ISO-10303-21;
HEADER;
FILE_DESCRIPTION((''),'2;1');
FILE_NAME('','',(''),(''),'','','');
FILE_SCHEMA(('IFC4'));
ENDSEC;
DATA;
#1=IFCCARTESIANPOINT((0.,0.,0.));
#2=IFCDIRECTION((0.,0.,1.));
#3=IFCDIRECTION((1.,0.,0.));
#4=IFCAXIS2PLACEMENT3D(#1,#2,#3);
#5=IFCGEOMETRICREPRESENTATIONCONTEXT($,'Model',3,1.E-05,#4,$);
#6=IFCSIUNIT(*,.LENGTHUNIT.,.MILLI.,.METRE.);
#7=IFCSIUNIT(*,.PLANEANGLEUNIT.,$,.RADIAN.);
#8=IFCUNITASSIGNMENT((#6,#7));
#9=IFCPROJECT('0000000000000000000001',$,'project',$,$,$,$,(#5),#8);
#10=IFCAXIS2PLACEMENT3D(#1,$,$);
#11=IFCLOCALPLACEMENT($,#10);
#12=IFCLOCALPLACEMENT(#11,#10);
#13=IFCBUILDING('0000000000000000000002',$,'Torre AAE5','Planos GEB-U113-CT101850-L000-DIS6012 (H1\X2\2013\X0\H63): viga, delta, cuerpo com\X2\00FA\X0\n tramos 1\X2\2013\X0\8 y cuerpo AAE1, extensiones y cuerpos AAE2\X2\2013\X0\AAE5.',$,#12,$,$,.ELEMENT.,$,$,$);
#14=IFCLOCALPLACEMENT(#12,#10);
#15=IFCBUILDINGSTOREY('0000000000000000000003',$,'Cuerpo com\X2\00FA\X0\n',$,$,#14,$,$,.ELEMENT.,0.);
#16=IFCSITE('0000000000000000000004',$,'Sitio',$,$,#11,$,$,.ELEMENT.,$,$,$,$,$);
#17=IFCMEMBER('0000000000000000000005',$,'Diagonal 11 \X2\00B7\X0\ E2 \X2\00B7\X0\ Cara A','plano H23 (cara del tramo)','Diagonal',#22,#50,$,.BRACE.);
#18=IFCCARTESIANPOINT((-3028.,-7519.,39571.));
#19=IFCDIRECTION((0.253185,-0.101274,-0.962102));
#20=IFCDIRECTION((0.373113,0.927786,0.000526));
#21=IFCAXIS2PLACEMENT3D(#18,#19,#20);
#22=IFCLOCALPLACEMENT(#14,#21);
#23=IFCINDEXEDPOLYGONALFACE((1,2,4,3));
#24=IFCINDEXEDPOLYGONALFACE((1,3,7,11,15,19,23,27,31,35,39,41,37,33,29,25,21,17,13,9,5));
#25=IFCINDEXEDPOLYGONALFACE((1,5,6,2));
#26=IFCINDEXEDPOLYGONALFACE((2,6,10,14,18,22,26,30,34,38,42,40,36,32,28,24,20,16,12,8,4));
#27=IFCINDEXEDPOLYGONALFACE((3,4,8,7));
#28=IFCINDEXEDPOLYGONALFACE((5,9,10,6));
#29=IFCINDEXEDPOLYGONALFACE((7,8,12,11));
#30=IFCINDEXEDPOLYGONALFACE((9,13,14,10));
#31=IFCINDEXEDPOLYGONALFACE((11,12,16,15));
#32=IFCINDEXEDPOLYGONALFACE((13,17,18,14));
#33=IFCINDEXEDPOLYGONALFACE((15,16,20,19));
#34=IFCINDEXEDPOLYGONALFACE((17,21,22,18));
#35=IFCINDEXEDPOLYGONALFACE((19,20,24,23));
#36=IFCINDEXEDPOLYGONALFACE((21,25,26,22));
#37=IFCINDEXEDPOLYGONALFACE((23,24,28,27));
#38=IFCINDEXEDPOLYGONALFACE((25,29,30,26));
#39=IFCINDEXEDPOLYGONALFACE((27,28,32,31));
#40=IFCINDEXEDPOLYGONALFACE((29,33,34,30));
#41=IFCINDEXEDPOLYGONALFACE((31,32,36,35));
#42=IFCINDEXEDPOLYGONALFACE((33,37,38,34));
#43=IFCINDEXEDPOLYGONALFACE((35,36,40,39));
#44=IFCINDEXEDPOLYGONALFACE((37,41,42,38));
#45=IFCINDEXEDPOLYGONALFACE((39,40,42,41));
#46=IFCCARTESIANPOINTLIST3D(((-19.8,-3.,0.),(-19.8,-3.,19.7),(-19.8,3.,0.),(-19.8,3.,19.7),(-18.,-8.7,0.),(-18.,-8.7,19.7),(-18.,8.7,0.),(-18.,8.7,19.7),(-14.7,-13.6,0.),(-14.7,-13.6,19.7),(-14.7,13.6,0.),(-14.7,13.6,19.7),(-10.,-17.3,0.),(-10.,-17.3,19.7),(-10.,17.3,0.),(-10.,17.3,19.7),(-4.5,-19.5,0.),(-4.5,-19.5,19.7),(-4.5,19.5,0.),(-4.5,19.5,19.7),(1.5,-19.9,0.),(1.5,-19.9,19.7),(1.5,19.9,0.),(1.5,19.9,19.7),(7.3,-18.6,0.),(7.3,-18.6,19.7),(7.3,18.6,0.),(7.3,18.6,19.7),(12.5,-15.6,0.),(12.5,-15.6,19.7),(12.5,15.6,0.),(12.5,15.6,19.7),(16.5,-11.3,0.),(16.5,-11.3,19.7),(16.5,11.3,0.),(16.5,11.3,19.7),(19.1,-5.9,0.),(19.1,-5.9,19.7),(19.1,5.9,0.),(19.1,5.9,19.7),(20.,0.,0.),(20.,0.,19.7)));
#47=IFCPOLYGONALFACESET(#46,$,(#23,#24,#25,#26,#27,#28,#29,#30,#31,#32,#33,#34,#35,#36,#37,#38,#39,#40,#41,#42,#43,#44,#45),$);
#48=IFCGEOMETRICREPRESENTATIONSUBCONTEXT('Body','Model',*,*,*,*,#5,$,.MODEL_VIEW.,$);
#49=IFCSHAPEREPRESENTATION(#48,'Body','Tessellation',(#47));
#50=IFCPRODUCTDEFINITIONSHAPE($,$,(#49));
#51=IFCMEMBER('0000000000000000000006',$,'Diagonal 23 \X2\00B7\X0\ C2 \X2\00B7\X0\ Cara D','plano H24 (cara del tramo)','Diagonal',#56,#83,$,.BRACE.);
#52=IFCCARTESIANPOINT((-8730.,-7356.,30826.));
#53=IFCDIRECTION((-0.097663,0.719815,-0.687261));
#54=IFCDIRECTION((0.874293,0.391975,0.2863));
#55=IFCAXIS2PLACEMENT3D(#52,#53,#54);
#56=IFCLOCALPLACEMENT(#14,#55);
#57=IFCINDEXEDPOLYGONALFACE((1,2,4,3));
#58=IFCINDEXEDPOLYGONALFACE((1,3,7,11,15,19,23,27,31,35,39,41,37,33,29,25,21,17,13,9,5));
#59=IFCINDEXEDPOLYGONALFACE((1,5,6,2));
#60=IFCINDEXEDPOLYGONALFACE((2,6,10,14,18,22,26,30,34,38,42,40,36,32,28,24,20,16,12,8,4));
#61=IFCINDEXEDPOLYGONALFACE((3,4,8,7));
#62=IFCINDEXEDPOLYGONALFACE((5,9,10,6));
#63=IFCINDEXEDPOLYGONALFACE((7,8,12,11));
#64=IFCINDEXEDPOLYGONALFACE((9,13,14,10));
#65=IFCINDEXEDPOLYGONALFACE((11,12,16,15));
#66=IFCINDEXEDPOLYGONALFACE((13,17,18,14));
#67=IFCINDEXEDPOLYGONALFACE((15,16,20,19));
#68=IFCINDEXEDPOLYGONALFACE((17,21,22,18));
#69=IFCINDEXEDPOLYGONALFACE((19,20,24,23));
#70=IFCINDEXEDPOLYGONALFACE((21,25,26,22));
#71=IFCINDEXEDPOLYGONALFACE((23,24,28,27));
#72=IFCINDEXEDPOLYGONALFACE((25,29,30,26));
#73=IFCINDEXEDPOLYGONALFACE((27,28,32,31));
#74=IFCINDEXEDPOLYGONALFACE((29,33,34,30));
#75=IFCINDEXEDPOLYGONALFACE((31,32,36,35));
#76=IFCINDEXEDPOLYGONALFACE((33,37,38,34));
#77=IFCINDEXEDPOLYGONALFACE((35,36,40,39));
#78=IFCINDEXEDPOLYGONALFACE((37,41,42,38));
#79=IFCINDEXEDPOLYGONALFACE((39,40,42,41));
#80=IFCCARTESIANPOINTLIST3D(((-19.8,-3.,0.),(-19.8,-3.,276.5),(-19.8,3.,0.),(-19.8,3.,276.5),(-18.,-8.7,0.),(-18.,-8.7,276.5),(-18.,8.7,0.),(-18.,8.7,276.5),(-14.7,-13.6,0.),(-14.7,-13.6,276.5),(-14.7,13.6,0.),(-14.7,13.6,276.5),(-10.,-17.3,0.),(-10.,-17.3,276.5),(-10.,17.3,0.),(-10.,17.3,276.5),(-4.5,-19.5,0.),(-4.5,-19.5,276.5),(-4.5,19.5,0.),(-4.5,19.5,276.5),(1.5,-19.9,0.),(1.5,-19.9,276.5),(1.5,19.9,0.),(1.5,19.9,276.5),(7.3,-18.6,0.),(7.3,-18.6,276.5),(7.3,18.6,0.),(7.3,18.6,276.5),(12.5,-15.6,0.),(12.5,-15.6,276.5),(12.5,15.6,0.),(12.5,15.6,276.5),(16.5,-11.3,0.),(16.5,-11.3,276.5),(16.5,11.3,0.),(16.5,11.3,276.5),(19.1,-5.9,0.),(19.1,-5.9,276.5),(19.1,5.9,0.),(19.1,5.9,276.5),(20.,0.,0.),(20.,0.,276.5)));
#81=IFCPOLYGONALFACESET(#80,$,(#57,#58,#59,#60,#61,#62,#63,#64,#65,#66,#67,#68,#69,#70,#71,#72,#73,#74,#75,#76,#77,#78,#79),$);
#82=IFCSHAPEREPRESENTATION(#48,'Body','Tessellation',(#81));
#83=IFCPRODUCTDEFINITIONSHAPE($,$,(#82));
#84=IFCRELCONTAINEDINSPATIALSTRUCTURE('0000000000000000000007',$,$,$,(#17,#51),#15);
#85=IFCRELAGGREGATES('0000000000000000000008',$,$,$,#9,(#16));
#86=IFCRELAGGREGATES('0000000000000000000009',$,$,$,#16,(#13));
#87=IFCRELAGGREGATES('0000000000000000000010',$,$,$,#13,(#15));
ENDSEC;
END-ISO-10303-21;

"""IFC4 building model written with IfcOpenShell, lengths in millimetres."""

from ifc_helpers import new_model, si_unit, frame, origin, origin_with_axes, place, context, subcontext, project, spatial, circle, extrude, element, save


model = new_model("IFC4")

# Units and contexts
model_context = context("Model", 3, precision=1e-05, world=origin_with_axes())
body_context = subcontext(model_context, "Body", "Model", "MODEL_VIEW")
ifc_project = project(units=[si_unit("LENGTHUNIT", "METRE", prefix="MILLI"), si_unit("PLANEANGLEUNIT", "RADIAN")], contexts=[model_context])

# Site, building, storey
site_placement = place(None, origin())
site = spatial("IfcSite", under=ifc_project, at=site_placement, Name="Sitio", CompositionType="ELEMENT")
building_placement = place(site_placement, origin())
building = spatial("IfcBuilding", under=site, at=building_placement, Name="Torre AAE5", Description="Planos GEB-U113-CT101850-L000-DIS6012 (H1–H63): viga, delta, cuerpo común tramos 1–8 y cuerpo AAE1, extensiones y cuerpos AAE2–AAE5.", CompositionType="ELEMENT")
storey_placement = place(building_placement, origin())
storey = spatial("IfcBuildingStorey", under=building, at=storey_placement, Name="Cuerpo común", CompositionType="ELEMENT", Elevation=0.0)

# Members
member_1_placement = place(storey_placement, frame((-3028.0, -7519.0, 39571.0), z_axis=(0.253185, -0.101274, -0.962102), x_axis=(0.373113, 0.927786, 0.000526)))
element("IfcMember", 1, at=member_1_placement, inside=storey, Name="Diagonal 11 · E2 · Cara A", Description="plano H23 (cara del tramo)", ObjectType="Diagonal", PredefinedType="BRACE", context=body_context, shape_type="SweptSolid", body=[
    extrude(circle(Radius=20.0), None, (0.0, 0.0, 1.0), 19.7),
])
member_2_placement = place(storey_placement, frame((-8730.0, -7356.0, 30826.0), z_axis=(-0.097663, 0.719815, -0.687261), x_axis=(0.874293, 0.391975, 0.2863)))
element("IfcMember", 2, at=member_2_placement, inside=storey, Name="Diagonal 23 · C2 · Cara D", Description="plano H24 (cara del tramo)", ObjectType="Diagonal", PredefinedType="BRACE", context=body_context, shape_type="SweptSolid", body=[
    extrude(circle(Radius=20.0), None, (0.0, 0.0, 1.0), 276.5),
])

save(model, "model.ifc")
